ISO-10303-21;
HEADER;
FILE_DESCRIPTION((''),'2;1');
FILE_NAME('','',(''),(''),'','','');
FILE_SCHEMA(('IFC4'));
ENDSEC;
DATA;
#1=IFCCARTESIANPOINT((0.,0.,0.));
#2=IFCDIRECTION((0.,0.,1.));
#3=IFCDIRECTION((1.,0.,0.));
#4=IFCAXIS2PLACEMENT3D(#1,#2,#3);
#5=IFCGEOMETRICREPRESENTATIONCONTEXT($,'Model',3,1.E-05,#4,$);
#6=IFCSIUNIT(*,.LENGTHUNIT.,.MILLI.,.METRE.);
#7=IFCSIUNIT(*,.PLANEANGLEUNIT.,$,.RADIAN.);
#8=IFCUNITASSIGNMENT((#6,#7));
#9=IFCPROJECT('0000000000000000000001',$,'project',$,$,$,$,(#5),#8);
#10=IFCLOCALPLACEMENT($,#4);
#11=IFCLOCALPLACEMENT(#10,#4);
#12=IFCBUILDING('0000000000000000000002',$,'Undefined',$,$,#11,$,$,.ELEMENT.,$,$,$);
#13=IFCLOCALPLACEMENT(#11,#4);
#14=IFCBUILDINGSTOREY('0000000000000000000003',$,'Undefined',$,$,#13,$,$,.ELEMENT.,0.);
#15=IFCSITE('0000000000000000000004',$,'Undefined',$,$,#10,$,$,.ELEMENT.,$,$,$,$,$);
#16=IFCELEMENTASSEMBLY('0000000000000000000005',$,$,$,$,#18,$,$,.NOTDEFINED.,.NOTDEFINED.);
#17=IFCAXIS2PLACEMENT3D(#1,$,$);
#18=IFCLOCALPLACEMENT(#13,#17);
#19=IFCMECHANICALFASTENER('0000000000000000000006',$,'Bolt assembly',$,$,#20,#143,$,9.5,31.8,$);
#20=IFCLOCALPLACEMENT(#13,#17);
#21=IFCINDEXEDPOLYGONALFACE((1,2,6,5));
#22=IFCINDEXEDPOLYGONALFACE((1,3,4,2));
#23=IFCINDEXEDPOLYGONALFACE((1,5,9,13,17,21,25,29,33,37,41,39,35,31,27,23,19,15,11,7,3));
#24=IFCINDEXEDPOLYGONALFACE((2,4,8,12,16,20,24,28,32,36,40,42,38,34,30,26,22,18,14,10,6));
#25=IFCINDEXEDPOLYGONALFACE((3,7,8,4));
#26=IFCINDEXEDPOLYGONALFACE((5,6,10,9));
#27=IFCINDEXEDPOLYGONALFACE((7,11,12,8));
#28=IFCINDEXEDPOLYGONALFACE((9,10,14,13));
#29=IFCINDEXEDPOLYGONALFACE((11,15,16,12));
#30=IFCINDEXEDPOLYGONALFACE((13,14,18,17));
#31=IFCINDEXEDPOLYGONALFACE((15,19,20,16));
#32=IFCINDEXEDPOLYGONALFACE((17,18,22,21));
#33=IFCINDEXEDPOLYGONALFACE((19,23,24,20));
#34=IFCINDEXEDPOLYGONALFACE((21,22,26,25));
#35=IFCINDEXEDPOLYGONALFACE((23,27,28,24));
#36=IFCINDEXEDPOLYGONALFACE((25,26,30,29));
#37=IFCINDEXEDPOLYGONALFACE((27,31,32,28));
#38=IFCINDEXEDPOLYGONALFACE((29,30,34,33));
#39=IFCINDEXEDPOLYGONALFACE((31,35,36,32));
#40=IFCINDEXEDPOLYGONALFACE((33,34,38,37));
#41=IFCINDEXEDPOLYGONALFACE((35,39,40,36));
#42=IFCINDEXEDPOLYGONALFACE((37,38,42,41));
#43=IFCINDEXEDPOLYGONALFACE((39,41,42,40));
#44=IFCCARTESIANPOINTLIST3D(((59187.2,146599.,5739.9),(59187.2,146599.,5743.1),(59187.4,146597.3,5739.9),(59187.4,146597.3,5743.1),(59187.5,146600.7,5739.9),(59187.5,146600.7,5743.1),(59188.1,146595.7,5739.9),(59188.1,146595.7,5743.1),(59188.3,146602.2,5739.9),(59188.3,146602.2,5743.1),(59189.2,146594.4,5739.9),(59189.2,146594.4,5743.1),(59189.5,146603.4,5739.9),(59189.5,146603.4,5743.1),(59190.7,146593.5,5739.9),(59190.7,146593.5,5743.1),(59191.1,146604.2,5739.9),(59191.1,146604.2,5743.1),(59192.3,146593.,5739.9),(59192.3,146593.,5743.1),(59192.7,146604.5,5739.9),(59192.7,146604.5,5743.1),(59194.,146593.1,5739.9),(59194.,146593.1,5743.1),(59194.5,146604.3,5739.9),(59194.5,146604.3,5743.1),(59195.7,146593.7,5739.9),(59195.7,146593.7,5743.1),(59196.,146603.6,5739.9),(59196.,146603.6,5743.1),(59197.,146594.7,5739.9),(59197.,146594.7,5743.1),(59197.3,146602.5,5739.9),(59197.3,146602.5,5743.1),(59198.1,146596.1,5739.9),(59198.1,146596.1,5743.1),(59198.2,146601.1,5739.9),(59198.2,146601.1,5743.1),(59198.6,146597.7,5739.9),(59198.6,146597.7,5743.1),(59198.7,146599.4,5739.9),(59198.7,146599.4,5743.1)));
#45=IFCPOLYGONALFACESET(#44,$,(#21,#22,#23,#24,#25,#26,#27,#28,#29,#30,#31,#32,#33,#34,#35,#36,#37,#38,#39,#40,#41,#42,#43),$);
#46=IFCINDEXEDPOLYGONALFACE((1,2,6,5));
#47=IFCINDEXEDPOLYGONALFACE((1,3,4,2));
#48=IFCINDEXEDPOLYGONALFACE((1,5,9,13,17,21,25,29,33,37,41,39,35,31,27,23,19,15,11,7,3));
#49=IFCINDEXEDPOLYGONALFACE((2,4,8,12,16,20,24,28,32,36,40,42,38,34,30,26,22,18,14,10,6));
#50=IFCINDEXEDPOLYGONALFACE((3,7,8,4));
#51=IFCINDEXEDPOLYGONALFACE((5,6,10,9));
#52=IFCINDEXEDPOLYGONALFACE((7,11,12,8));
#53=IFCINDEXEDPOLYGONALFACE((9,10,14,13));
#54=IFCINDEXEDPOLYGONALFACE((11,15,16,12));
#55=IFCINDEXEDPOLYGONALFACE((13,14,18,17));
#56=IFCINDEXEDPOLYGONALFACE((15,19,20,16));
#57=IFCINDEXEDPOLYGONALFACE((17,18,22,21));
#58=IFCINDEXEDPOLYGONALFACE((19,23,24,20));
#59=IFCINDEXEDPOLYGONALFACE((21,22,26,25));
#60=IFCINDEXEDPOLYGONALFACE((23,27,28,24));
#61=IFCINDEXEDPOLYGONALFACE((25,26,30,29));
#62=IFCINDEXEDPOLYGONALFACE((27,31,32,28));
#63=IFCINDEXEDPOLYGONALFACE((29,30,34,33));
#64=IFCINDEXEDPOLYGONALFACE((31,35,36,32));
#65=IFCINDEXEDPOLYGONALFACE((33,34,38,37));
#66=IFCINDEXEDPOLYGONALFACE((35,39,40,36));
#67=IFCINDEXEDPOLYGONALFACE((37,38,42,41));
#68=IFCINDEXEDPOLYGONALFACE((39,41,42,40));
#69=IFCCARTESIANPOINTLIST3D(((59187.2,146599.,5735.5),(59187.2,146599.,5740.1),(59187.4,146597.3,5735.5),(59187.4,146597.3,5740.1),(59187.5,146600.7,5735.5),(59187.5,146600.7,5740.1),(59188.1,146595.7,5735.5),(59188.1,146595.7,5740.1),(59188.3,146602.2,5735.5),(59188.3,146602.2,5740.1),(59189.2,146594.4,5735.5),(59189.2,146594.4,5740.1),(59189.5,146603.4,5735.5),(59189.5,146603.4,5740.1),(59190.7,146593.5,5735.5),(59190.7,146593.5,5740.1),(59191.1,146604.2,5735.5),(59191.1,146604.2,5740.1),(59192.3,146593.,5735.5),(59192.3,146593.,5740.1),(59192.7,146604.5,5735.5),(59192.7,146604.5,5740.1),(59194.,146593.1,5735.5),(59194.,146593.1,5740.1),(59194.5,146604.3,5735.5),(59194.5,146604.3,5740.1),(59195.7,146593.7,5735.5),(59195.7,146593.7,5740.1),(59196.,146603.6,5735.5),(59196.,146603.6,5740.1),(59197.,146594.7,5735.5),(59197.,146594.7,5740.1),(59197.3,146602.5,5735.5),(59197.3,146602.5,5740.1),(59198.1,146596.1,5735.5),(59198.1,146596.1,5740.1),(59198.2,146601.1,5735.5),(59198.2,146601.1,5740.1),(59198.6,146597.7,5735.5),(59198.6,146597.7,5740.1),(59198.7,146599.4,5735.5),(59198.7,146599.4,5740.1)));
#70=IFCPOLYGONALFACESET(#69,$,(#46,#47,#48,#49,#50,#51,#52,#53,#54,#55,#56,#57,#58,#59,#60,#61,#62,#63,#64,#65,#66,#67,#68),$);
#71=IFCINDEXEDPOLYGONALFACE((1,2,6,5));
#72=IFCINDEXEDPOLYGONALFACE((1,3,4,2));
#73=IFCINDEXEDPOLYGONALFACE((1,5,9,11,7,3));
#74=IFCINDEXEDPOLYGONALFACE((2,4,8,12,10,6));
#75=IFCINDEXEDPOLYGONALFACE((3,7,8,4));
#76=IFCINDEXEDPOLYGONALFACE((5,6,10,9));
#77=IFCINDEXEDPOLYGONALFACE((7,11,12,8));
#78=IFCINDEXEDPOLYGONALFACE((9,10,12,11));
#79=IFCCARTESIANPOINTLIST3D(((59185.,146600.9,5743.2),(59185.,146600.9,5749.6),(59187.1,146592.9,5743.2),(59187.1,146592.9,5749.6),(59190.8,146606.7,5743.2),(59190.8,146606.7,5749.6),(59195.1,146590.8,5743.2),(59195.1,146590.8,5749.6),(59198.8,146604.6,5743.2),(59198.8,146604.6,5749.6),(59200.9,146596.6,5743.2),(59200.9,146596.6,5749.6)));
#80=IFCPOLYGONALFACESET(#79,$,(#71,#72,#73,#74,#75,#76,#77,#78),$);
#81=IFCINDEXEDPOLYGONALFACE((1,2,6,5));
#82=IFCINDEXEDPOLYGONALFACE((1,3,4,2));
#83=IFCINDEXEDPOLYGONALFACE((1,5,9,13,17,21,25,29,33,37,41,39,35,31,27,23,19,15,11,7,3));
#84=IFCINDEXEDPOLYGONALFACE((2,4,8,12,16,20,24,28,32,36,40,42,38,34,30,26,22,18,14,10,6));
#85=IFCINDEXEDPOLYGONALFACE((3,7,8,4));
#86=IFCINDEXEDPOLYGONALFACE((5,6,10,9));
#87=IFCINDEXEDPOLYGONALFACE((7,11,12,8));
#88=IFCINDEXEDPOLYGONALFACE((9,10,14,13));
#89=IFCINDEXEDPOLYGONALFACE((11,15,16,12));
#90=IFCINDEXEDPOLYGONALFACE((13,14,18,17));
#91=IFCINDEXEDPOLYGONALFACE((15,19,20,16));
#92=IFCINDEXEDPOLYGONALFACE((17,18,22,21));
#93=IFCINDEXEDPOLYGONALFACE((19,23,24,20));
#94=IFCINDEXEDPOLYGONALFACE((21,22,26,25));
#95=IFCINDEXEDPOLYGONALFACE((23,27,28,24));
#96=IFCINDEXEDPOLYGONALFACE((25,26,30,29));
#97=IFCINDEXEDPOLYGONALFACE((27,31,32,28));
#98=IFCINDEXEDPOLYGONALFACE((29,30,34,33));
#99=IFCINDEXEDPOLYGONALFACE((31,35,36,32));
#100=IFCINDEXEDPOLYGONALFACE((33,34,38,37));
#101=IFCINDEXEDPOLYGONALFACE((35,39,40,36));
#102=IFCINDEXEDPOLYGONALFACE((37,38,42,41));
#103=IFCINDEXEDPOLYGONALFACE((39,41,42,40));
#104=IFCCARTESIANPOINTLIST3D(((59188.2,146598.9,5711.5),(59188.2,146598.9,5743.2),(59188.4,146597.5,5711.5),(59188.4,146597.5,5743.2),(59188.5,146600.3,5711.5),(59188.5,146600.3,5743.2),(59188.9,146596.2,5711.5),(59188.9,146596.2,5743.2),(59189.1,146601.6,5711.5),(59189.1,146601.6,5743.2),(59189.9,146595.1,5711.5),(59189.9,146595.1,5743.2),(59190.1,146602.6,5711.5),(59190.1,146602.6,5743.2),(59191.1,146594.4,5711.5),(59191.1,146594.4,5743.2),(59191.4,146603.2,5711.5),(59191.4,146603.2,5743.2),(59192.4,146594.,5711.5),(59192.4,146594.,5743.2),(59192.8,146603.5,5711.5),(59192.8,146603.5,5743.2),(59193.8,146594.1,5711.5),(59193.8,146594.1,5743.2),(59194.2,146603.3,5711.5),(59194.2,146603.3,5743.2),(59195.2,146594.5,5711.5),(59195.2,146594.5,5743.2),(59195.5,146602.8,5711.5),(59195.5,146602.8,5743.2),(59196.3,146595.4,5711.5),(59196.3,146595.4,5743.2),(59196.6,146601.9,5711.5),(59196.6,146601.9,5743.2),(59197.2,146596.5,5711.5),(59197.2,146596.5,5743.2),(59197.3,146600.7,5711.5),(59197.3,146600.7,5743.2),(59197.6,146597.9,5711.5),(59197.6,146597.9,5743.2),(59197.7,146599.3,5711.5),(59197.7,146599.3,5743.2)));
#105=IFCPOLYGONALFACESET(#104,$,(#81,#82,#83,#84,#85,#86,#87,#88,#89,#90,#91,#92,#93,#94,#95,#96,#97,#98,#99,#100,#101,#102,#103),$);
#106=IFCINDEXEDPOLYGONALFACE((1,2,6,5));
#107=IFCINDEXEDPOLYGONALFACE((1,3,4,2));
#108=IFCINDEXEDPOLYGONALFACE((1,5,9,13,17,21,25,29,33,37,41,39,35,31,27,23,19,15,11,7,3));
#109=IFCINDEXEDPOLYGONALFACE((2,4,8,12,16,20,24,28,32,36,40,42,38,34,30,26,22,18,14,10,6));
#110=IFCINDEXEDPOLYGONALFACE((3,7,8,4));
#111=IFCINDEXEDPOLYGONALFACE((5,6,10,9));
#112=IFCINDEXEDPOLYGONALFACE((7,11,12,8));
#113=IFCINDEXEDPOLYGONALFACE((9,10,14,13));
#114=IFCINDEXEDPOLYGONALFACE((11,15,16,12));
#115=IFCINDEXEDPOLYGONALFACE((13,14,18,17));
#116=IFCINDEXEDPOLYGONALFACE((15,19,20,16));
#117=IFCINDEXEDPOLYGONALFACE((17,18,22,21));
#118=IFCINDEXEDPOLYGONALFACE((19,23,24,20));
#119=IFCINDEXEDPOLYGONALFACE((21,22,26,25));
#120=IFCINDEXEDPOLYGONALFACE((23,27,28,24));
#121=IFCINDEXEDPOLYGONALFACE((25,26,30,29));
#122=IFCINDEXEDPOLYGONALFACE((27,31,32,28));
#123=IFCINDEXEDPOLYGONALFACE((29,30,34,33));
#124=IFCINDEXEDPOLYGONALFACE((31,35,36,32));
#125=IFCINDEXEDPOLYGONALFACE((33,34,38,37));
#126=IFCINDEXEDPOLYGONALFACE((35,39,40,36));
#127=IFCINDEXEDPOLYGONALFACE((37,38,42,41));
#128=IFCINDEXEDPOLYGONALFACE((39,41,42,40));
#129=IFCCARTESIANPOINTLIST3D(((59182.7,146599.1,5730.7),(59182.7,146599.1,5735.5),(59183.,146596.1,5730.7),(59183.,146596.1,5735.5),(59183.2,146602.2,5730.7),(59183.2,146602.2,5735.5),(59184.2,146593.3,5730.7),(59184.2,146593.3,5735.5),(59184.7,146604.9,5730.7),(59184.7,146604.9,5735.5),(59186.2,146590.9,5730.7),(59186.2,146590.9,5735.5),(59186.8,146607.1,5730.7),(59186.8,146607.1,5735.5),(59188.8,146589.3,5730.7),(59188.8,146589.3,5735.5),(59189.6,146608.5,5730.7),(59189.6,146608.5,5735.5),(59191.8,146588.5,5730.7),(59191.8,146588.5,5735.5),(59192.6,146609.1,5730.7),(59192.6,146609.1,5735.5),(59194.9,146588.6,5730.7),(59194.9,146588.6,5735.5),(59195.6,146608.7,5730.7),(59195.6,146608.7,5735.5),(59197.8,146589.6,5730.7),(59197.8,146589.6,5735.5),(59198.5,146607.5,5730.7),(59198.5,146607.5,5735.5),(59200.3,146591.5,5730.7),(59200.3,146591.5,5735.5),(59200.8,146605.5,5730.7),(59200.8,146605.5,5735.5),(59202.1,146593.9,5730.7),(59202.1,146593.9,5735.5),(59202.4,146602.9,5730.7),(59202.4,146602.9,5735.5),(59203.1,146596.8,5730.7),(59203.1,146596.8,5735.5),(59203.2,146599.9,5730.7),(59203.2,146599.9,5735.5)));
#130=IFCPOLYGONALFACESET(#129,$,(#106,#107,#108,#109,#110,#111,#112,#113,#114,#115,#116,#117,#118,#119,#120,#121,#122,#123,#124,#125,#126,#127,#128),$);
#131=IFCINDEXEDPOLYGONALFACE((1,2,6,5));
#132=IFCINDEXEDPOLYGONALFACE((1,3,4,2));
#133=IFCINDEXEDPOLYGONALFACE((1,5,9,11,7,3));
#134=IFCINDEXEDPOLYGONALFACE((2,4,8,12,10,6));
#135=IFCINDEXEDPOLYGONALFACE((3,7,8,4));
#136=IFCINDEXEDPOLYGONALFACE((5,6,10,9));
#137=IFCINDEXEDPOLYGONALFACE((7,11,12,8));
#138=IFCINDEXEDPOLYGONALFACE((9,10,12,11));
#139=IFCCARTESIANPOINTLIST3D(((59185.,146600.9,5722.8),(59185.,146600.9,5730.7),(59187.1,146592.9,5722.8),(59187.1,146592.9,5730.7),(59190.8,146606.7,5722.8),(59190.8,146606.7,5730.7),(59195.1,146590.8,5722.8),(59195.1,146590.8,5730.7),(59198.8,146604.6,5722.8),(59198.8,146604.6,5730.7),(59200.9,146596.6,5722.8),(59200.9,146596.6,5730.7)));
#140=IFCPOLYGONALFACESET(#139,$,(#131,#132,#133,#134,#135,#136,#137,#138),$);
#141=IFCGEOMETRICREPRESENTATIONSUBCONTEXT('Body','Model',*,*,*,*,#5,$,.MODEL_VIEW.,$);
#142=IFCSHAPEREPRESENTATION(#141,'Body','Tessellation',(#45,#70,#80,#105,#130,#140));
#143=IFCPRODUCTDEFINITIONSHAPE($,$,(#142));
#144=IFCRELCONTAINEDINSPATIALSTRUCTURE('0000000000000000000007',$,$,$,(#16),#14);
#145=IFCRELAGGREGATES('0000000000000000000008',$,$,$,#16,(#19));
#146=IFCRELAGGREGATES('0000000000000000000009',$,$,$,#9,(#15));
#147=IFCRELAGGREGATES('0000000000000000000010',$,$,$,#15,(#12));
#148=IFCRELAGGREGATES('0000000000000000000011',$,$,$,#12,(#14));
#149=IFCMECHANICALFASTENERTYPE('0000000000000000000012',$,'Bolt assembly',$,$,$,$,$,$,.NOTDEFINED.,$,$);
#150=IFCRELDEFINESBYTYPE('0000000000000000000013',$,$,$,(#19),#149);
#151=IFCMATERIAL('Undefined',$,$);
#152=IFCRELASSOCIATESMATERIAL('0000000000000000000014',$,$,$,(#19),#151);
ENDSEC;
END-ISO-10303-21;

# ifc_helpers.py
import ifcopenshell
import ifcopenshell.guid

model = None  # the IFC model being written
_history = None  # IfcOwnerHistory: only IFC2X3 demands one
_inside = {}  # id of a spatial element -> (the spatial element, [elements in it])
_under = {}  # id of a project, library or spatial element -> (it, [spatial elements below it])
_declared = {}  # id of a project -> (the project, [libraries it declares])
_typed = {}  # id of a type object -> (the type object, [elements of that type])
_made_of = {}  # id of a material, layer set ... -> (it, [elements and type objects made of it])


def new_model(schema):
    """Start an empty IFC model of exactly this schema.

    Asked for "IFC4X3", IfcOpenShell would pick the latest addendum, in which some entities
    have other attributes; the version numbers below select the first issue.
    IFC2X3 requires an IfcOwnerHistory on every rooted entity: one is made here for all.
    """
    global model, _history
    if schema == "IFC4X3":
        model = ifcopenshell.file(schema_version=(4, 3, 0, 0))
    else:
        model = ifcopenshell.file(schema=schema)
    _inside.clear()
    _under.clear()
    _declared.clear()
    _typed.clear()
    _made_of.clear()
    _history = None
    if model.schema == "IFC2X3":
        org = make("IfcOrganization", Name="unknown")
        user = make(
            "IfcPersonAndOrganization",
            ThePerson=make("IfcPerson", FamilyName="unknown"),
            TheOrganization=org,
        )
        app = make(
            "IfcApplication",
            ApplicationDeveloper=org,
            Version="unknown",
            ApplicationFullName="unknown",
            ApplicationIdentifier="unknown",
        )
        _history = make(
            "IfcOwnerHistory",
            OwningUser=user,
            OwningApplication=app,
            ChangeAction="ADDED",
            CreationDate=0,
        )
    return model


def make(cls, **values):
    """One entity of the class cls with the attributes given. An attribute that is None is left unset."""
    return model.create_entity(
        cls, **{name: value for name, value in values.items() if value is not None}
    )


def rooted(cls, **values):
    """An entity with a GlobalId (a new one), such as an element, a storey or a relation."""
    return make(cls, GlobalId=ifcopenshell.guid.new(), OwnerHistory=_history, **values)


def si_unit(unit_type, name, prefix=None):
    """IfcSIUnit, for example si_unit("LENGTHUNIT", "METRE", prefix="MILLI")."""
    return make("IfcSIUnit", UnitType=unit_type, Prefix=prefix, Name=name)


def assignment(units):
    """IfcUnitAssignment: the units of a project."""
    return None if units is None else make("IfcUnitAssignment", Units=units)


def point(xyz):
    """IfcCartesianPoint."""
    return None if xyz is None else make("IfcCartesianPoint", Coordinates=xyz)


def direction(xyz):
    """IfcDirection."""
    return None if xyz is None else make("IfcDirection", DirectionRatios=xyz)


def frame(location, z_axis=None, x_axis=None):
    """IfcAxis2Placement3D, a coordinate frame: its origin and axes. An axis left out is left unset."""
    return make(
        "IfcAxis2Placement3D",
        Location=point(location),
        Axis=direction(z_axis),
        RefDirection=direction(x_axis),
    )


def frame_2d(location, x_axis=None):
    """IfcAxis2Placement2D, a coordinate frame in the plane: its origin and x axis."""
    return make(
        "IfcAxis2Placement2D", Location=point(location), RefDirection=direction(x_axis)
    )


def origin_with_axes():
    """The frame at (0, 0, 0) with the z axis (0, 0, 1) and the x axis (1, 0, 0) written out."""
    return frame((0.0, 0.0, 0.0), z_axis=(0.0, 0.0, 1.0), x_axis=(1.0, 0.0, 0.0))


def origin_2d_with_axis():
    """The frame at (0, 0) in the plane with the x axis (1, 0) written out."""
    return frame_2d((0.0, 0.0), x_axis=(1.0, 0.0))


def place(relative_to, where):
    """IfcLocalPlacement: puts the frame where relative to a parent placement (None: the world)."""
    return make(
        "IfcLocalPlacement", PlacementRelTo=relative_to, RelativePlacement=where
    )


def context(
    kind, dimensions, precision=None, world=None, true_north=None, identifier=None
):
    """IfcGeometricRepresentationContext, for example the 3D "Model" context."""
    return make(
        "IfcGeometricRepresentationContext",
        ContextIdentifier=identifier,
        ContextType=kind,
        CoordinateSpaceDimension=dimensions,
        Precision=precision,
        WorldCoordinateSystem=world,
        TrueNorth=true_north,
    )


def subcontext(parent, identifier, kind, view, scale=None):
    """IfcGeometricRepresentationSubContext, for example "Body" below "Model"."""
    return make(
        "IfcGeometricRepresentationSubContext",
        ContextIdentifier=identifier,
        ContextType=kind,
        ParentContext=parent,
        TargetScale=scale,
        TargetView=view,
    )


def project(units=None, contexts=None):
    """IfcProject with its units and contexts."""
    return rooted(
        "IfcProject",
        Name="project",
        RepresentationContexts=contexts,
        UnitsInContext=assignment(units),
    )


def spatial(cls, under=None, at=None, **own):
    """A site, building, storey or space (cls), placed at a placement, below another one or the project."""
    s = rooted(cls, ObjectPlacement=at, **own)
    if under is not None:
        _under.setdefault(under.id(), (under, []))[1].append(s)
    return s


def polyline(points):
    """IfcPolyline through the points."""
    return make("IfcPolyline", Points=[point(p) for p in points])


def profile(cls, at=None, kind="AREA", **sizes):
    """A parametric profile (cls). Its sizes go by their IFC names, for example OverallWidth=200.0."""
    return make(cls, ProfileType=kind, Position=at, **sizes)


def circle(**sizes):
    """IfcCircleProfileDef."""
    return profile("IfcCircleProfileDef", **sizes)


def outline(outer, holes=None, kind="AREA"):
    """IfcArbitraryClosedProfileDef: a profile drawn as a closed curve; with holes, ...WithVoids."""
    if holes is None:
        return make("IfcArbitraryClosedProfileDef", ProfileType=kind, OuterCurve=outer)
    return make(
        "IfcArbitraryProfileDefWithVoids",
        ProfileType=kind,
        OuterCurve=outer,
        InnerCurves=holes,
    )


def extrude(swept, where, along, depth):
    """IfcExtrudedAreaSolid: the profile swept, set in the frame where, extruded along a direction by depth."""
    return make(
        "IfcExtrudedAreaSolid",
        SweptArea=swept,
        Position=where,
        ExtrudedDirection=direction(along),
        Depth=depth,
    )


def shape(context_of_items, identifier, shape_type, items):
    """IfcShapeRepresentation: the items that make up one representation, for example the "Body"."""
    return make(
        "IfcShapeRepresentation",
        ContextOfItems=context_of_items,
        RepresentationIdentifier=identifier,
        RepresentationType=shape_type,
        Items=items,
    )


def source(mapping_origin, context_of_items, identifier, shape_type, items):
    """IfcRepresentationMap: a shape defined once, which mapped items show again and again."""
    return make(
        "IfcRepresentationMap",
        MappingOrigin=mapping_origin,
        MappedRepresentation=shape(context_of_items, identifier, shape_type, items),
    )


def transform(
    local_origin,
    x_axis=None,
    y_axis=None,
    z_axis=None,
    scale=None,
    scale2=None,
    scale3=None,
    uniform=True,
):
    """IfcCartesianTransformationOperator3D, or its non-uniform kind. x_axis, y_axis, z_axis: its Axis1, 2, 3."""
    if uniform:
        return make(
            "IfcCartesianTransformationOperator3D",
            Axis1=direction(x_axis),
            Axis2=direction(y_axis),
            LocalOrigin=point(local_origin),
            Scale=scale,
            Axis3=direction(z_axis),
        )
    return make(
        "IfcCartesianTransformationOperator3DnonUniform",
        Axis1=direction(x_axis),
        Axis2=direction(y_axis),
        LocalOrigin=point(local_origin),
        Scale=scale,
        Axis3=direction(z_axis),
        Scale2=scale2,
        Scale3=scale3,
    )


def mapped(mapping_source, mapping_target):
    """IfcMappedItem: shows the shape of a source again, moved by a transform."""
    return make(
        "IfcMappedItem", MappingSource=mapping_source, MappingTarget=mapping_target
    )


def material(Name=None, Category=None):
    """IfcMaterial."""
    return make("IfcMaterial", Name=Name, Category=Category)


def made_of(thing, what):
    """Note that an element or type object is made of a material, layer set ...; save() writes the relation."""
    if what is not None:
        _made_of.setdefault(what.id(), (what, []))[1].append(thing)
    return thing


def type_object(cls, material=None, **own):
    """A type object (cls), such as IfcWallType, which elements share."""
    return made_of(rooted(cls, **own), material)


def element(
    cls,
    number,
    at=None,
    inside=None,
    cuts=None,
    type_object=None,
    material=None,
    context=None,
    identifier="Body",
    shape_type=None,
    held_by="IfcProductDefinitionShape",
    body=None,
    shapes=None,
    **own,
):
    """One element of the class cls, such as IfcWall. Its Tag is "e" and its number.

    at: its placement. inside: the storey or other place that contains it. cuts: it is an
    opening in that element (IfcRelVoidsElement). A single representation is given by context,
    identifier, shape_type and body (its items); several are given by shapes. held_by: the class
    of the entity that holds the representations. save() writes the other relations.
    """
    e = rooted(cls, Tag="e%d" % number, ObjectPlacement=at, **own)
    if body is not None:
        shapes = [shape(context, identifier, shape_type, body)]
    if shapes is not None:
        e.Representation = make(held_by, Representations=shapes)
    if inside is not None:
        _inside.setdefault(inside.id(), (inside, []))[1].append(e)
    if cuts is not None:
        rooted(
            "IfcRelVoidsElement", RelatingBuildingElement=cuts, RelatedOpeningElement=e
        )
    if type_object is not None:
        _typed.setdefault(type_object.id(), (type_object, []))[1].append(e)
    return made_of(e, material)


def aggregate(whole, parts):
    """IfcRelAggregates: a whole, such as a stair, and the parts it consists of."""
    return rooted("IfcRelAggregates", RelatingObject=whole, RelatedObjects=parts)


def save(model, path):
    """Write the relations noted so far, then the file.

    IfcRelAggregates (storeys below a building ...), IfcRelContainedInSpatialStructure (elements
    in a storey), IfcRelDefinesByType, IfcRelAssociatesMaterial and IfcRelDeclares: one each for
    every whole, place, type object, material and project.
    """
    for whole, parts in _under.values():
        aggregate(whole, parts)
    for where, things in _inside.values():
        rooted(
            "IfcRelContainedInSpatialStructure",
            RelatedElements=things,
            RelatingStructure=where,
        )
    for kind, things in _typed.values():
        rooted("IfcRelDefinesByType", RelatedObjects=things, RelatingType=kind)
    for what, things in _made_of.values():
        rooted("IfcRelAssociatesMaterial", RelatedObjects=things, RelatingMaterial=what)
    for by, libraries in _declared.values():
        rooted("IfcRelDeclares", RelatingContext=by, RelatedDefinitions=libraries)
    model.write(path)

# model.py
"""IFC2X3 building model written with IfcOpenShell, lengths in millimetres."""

from ifc_helpers import new_model, si_unit, frame, origin_with_axes, origin_2d_with_axis, place, context, subcontext, project, spatial, polyline, circle, outline, extrude, source, transform, mapped, material, type_object, element, aggregate, save


model = new_model("IFC2X3")

# Units and contexts
model_context = context("Model", 3, precision=1e-05, world=origin_with_axes())
body_context = subcontext(model_context, "Body", "Model", "MODEL_VIEW")
ifc_project = project(units=[si_unit("LENGTHUNIT", "METRE", prefix="MILLI"), si_unit("PLANEANGLEUNIT", "RADIAN")], contexts=[model_context])

# Site, building, storey
site_placement = place(None, origin_with_axes())
site = spatial("IfcSite", under=ifc_project, at=site_placement, Name="Undefined", CompositionType="ELEMENT")
building_placement = place(site_placement, origin_with_axes())
building = spatial("IfcBuilding", under=site, at=building_placement, Name="Undefined", CompositionType="ELEMENT")
storey_placement = place(building_placement, origin_with_axes())
storey = spatial("IfcBuildingStorey", under=building, at=storey_placement, Name="Undefined", CompositionType="ELEMENT", Elevation=0.0)

# Element assembly
assembly_1_placement = place(storey_placement, origin_with_axes())
assembly_1 = element("IfcElementAssembly", 1, at=assembly_1_placement, inside=storey, AssemblyPlace="NOTDEFINED", PredefinedType="NOTDEFINED")

# Mechanical fastener
ifc_material_1 = material(Name="Undefined")
mechanical_fastener_type = type_object("IfcMechanicalFastenerType", Name="Bolt assembly")
shared_shape_1 = source(origin_with_axes(), body_context, "Body", "SweptSolid", [
    extrude(circle(Radius=5.8, at=origin_2d_with_axis()), frame((0.0, -7.6, 0.0), z_axis=(0.0, 1.0, 0.0), x_axis=(1.0, 0.0, 0.0)), (0.0, 0.0, 1.0), 3.2),
    extrude(circle(Radius=5.8, at=origin_2d_with_axis()), frame((0.0, -4.6, 0.0), z_axis=(0.0, 1.0, 0.0), x_axis=(1.0, 0.0, 0.0)), (0.0, 0.0, 1.0), 4.6),
    extrude(outline(polyline([(7.1, -4.1), (7.1, 4.1), (0.0, 8.2), (-7.1, 4.1), (-7.1, -4.1), (0.0, -8.2), (7.1, -4.1)])), frame((0.0, -14.0, 0.0), z_axis=(0.0, 1.0, 0.0), x_axis=(1.0, 0.0, 0.0)), (0.0, 0.0, 1.0), 6.3),
    extrude(circle(Radius=4.8, at=origin_2d_with_axis()), frame((0.0, -7.7, 0.0), z_axis=(0.0, 1.0, 0.0), x_axis=(1.0, 0.0, 0.0)), (0.0, 0.0, 1.0), 31.8),
    extrude(circle(Radius=10.3, at=origin_2d_with_axis()), frame((0.0, 0.0, 0.0), z_axis=(0.0, 1.0, 0.0), x_axis=(1.0, 0.0, 0.0)), (0.0, 0.0, 1.0), 4.8),
    extrude(outline(polyline([(7.1, -4.1), (7.1, 4.1), (0.0, 8.2), (-7.1, 4.1), (-7.1, -4.1), (0.0, -8.2), (7.1, -4.1)])), frame((0.0, 4.8, 0.0), z_axis=(0.0, 1.0, 0.0), x_axis=(1.0, 0.0, 0.0)), (0.0, 0.0, 1.0), 7.9),
])
mechanical_fastener_1_placement = place(assembly_1_placement, frame((59193.0, 146598.7, 5735.5), z_axis=(0.707107, 0.707107, 0.0), x_axis=(0.707107, -0.707107, 0.0)))
mechanical_fastener_1 = element("IfcMechanicalFastener", 2, at=mechanical_fastener_1_placement, type_object=mechanical_fastener_type, material=ifc_material_1, Name="Bolt assembly", NominalDiameter=9.5, NominalLength=31.8, context=body_context, shape_type="MappedRepresentation", body=[
    mapped(shared_shape_1, transform((0.0, 0.0, 0.0))),
])
aggregate(assembly_1, [mechanical_fastener_1])

save(model, "model.ifc")
